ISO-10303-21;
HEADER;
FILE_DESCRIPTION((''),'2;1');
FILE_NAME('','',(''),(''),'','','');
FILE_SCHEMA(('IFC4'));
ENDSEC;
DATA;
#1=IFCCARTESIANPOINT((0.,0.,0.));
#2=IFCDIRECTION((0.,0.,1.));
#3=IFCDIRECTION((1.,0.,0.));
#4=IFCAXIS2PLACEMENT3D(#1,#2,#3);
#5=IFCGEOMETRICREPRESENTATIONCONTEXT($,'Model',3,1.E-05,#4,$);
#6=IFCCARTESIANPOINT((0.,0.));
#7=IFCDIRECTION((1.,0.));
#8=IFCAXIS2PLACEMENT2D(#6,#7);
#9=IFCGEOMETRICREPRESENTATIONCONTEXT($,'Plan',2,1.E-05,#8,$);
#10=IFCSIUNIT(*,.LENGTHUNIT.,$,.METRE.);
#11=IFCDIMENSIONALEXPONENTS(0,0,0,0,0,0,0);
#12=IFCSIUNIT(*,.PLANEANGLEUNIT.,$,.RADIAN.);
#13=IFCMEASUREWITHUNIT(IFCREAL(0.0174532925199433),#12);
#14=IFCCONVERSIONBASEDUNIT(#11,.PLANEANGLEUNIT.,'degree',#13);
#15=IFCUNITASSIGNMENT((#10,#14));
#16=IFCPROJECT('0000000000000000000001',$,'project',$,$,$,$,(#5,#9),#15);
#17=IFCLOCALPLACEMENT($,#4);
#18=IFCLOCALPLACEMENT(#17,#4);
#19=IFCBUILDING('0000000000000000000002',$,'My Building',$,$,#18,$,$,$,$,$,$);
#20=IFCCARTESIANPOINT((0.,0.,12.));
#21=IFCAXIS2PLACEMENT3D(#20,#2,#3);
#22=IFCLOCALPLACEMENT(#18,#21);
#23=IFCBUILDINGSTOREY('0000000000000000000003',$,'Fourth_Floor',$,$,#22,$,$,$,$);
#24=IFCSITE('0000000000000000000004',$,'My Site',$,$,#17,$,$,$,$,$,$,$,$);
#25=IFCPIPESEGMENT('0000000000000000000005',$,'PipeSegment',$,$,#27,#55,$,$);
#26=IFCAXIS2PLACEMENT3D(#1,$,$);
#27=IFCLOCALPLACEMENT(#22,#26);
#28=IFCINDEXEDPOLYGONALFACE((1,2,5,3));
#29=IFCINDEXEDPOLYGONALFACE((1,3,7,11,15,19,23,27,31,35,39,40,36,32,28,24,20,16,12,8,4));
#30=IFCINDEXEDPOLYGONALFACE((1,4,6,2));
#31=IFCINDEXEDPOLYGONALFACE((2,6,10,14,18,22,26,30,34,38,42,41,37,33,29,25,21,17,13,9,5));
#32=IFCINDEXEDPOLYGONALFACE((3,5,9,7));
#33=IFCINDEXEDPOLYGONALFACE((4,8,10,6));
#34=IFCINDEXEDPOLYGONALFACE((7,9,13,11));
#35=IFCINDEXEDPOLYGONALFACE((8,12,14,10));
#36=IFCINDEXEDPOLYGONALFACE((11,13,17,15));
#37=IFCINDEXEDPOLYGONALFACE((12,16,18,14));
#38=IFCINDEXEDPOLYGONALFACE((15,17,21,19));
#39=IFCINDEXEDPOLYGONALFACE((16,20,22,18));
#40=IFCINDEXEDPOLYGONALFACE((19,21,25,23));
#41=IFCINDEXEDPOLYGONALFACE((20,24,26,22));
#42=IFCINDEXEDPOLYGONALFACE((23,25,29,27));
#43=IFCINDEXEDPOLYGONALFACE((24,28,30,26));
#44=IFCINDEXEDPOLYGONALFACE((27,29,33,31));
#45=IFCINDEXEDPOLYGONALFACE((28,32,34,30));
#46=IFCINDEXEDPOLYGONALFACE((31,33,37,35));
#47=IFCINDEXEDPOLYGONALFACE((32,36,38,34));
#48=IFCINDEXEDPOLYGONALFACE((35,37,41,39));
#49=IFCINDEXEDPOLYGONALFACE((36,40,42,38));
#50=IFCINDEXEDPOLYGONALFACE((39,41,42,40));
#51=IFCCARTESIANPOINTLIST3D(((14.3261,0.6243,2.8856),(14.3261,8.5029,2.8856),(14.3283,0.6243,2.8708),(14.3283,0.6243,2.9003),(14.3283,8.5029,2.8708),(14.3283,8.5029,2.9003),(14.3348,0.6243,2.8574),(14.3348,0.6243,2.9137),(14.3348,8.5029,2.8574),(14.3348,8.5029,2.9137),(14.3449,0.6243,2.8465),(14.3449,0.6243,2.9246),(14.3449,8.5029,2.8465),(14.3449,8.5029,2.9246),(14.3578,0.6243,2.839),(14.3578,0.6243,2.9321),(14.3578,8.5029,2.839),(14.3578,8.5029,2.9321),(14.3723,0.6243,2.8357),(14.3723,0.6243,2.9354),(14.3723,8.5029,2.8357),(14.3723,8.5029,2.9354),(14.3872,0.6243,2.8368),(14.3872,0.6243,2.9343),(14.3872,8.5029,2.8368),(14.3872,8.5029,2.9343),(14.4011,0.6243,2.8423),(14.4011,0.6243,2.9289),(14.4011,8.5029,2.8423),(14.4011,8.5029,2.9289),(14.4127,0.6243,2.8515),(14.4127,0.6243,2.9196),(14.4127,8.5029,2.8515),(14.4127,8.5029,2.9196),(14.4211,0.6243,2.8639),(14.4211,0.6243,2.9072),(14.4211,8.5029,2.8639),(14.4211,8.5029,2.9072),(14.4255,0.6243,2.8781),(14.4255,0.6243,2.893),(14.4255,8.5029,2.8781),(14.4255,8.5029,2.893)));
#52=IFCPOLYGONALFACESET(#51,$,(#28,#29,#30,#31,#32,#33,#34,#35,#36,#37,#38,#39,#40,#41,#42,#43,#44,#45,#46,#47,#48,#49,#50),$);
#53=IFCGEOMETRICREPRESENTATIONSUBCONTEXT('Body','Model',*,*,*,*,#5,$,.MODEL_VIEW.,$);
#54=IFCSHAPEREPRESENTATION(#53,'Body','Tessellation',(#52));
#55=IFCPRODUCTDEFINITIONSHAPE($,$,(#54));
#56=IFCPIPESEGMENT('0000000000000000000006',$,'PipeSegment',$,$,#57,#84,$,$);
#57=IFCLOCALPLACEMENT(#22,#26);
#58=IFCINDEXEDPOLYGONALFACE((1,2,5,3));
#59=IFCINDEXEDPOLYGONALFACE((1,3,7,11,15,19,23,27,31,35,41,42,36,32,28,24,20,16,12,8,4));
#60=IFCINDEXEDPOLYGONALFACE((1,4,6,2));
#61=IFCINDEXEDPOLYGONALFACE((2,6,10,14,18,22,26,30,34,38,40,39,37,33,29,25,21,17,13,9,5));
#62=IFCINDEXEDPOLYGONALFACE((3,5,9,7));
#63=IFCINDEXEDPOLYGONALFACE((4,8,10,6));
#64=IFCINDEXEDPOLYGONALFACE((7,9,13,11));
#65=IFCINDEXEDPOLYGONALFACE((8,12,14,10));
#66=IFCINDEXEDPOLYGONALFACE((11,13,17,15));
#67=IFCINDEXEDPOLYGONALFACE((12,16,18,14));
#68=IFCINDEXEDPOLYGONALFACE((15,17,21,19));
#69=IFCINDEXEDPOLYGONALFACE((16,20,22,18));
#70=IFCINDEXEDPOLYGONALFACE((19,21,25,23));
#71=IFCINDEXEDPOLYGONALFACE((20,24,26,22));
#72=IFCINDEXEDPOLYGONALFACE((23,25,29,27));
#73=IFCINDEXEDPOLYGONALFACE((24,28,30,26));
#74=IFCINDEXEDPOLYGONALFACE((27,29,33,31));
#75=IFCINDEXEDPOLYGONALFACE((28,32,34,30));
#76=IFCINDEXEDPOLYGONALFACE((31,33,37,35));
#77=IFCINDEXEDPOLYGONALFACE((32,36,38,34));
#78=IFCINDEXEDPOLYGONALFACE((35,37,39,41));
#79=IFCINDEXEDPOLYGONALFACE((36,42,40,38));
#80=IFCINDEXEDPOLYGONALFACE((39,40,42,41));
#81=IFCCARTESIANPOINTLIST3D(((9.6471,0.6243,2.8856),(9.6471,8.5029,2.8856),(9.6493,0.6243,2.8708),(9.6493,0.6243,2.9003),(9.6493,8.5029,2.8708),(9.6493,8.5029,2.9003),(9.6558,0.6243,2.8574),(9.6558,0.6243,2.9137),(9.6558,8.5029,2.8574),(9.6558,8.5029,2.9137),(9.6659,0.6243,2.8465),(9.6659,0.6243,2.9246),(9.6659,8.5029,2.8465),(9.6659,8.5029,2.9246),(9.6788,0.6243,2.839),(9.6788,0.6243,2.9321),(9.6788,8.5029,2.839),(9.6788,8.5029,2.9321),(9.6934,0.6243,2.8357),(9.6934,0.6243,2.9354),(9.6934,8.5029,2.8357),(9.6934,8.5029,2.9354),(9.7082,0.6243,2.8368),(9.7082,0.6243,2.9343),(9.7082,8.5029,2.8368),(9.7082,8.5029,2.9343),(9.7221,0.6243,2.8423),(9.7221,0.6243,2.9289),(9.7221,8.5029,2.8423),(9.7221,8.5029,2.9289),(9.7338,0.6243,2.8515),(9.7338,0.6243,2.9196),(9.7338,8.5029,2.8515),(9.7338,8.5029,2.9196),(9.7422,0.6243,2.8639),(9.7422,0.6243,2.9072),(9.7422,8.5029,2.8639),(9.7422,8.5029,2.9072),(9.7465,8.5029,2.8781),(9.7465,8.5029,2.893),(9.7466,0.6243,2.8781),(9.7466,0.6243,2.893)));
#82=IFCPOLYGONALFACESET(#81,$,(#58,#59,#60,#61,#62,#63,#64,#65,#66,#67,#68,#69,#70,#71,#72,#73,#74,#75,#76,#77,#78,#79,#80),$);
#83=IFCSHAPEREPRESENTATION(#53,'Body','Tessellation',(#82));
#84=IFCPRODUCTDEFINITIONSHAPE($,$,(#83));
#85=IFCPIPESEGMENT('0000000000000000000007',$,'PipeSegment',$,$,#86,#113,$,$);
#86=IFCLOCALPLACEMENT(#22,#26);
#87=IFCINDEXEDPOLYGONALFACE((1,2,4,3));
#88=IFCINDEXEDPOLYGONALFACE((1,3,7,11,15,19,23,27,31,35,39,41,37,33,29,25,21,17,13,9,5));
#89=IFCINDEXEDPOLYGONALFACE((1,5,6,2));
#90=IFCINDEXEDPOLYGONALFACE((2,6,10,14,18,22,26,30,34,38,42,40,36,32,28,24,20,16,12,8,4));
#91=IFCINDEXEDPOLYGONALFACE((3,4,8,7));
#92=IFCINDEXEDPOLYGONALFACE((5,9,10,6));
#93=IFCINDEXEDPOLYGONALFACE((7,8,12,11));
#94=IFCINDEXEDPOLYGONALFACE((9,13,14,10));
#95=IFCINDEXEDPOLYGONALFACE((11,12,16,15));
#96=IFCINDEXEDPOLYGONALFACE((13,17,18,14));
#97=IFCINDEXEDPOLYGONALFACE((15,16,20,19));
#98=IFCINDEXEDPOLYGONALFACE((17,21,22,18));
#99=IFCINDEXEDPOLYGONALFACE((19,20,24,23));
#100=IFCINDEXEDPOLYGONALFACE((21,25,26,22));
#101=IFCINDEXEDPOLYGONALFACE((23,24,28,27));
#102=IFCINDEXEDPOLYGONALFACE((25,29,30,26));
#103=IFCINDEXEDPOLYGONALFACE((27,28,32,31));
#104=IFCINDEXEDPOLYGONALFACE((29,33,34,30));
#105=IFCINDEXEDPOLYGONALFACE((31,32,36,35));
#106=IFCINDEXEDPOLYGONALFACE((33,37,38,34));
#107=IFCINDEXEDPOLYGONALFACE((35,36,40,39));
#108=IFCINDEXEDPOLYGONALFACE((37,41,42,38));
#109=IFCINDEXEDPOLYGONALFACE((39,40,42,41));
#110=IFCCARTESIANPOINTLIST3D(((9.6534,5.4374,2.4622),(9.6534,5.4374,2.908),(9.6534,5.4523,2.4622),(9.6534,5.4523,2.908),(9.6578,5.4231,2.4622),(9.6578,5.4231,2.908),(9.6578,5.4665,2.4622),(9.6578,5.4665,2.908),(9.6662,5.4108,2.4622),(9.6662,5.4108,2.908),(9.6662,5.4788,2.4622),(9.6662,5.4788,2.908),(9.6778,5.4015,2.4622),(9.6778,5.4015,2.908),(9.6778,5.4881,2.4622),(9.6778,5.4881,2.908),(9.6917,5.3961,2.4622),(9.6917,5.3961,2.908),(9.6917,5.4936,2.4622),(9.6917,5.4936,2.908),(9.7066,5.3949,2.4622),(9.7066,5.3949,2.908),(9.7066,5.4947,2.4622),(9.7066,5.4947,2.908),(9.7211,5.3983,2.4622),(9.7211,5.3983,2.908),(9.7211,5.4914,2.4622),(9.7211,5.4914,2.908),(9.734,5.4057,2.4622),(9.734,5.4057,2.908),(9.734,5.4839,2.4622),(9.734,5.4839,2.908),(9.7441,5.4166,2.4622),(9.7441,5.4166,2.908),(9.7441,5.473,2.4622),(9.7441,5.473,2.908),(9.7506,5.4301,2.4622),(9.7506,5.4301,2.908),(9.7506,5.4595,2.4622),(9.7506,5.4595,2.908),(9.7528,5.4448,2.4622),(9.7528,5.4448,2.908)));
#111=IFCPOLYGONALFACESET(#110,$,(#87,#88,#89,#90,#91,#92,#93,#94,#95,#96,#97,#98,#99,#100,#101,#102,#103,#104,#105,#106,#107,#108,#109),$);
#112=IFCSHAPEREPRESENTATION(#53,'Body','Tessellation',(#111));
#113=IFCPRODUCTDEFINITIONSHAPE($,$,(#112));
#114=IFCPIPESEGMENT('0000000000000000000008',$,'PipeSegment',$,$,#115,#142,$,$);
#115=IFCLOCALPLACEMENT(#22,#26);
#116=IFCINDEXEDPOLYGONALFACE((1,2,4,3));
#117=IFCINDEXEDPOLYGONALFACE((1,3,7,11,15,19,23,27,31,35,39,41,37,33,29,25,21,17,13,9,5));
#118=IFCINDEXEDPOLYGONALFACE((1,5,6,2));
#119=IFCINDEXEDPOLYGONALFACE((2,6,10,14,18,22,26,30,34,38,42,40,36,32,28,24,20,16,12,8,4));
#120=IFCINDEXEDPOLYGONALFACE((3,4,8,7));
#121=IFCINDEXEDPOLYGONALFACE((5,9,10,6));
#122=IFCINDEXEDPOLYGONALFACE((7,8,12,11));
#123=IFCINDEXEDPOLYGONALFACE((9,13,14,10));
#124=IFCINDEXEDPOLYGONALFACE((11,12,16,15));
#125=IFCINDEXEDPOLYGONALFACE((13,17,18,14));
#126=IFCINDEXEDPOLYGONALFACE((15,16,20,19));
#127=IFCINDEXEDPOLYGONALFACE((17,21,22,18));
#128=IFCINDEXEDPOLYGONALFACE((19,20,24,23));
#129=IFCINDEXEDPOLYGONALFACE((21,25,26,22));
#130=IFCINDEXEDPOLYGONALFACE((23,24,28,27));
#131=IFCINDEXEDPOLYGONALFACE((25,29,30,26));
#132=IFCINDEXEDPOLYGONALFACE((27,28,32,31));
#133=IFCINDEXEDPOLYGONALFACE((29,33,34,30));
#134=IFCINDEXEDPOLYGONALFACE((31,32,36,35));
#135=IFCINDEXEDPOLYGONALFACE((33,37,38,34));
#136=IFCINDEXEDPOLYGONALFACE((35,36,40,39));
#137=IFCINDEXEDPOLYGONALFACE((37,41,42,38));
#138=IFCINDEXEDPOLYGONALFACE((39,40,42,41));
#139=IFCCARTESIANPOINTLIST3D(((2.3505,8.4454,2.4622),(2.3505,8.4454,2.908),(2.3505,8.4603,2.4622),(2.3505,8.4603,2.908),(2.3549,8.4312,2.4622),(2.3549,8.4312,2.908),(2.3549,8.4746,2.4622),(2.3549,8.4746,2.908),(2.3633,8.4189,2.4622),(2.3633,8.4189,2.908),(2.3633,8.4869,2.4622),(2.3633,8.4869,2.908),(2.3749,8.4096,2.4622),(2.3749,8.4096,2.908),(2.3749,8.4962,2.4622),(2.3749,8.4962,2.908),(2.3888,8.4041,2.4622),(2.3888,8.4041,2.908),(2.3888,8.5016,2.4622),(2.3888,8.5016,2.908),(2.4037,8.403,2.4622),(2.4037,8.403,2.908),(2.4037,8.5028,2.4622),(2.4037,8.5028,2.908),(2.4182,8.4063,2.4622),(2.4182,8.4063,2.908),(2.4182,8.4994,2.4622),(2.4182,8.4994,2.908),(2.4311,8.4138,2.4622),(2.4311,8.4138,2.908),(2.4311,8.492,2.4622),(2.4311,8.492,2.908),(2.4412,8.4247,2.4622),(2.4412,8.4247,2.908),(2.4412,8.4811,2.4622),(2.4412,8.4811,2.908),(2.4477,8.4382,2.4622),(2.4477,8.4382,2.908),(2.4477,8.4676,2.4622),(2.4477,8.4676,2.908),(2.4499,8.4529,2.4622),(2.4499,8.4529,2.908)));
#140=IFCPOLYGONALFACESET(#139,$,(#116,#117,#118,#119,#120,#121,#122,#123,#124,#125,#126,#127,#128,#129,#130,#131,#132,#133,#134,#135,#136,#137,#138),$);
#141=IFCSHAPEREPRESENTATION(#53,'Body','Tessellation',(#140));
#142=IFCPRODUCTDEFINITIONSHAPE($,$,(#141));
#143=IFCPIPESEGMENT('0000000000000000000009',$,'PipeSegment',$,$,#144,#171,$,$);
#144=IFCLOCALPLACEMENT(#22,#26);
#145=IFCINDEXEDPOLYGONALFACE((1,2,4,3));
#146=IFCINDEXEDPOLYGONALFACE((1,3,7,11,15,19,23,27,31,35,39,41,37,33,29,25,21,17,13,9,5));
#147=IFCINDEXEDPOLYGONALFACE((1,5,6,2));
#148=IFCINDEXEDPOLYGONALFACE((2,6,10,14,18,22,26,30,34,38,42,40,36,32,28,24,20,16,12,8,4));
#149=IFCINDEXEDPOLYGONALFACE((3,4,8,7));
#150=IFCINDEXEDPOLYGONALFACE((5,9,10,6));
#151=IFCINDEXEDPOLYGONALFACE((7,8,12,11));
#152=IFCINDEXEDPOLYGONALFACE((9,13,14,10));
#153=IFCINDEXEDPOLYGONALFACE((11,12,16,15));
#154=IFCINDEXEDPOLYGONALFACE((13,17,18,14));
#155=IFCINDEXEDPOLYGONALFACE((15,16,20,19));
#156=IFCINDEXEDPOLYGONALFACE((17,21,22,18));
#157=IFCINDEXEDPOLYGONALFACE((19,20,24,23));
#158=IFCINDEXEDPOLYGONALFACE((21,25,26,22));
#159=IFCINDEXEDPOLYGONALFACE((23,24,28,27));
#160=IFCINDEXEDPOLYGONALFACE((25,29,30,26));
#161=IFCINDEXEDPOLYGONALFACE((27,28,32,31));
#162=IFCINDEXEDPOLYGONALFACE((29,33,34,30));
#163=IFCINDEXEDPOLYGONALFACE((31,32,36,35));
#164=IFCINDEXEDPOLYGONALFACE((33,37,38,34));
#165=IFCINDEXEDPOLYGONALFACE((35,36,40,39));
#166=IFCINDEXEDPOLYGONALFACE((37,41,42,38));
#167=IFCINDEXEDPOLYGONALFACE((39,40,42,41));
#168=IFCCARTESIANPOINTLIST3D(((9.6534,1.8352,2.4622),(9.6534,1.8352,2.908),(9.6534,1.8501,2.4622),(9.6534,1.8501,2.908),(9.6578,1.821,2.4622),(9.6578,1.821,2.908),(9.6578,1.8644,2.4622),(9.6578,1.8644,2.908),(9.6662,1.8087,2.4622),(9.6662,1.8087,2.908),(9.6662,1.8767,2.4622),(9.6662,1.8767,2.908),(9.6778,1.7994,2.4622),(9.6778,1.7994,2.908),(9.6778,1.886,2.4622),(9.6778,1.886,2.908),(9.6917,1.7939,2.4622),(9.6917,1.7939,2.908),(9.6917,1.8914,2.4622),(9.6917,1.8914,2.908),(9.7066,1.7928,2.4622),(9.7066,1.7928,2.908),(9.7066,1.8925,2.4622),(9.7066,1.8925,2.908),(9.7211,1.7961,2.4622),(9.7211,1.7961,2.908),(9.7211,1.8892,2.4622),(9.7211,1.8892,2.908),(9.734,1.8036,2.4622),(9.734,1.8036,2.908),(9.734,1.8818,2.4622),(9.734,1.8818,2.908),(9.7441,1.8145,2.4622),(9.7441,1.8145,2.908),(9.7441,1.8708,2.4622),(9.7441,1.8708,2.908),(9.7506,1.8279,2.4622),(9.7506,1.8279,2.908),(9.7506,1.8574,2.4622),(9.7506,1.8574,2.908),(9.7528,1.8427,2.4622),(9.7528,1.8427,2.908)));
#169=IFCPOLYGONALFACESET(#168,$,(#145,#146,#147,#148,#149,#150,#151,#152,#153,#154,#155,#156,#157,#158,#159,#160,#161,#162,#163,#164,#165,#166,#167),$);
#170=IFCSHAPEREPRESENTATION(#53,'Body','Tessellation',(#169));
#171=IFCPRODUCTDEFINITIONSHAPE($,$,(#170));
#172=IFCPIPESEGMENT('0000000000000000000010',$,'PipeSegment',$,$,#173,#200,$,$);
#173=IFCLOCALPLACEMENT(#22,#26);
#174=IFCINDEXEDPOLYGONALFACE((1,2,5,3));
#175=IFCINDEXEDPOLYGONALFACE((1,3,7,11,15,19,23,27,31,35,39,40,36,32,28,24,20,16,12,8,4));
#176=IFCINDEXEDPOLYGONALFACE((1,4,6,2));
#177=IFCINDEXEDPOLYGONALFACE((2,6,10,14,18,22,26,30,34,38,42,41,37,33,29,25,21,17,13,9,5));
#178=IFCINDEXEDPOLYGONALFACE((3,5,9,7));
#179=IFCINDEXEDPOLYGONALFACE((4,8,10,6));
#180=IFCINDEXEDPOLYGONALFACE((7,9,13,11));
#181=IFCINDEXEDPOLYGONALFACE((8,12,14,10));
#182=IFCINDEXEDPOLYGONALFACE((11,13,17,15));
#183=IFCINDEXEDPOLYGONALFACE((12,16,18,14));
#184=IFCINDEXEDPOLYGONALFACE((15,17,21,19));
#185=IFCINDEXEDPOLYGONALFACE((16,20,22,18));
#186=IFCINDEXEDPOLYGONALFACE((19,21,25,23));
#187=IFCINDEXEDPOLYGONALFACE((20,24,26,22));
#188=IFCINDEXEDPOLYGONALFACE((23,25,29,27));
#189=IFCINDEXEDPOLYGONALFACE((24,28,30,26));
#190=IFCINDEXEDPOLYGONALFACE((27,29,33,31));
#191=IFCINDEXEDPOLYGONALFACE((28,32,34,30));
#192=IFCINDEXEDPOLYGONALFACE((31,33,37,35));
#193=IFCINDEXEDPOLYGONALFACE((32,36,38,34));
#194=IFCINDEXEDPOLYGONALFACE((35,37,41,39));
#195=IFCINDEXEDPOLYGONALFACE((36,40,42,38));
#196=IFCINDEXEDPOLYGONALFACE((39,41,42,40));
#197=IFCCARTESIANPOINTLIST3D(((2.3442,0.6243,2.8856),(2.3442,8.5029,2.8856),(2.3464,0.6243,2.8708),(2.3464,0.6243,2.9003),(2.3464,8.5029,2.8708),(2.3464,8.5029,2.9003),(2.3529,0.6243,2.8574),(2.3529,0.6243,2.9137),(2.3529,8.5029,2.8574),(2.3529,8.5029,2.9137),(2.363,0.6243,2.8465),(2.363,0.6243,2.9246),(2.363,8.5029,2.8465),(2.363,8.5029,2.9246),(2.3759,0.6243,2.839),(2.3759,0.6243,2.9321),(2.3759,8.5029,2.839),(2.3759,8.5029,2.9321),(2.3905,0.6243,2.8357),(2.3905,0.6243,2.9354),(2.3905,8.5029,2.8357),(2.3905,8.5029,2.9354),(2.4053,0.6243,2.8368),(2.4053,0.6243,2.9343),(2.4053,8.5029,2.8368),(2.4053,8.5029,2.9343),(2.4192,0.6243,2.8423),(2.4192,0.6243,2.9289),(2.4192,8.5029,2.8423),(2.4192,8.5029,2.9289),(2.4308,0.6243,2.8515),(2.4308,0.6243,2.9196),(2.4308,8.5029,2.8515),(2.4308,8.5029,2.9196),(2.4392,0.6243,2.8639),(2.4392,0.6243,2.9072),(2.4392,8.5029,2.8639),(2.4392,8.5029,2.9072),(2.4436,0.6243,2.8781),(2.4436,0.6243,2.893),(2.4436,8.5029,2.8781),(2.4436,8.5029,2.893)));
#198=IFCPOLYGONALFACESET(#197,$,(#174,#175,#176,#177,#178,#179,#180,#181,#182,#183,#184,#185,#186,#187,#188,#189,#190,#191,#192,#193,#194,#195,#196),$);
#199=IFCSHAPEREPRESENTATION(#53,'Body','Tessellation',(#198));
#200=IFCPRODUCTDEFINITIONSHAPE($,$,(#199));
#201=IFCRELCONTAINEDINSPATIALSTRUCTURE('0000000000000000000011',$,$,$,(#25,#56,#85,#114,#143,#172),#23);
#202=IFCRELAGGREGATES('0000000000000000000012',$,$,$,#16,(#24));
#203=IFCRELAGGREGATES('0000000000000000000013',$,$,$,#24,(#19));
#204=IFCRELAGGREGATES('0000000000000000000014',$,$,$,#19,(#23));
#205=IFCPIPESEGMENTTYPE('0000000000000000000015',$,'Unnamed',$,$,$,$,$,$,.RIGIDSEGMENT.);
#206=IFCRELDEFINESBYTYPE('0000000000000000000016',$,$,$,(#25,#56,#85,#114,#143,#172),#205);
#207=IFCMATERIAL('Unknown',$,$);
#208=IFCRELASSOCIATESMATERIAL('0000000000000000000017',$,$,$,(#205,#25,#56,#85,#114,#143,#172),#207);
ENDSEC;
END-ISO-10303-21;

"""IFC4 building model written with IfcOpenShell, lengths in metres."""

from ifc_helpers import new_model, entity, si_unit, converted_unit, frame, origin_with_axes, origin_2d_with_axis, place, context, subcontext, project, spatial, circle, extrude, material, material_profile, profile_set, profile_usage, type_object, element, save


model = new_model("IFC4")

# Units and contexts
model_context = context("Model", 3, precision=1e-05, world=origin_with_axes())
plan_context = context("Plan", 2, precision=1e-05, world=origin_2d_with_axis())
body_context_1 = subcontext(model_context, "Body", "Model", "MODEL_VIEW")
ifc_project = project(units=[si_unit("LENGTHUNIT", "METRE"), converted_unit("PLANEANGLEUNIT", "degree", entity("IfcReal", 0.0174532925199433), si_unit("PLANEANGLEUNIT", "RADIAN"), dimensions=[0, 0, 0, 0, 0, 0, 0])], contexts=[model_context, plan_context])

# Site, building, storey
site_placement = place(None, origin_with_axes())
site = spatial("IfcSite", under=ifc_project, at=site_placement, Name="My Site")
building_placement = place(site_placement, origin_with_axes())
building = spatial("IfcBuilding", under=site, at=building_placement, Name="My Building")
storey_placement = place(building_placement, frame((0.0, 0.0, 12.0), z_axis=(0.0, 0.0, 1.0), x_axis=(1.0, 0.0, 0.0)))
storey = spatial("IfcBuildingStorey", under=building, at=storey_placement, Name="Fourth_Floor")

# Shared definitions
ifc_material = material(Name="Unknown")

# Pipe segments
ifc_material_profile_1 = material_profile(ifc_material, circle(Radius=0.05))
ifc_profile_set_1 = profile_set([ifc_material_profile_1])
pipe_segment_type = type_object("IfcPipeSegmentType", Name="Unnamed", PredefinedType="RIGIDSEGMENT", material=ifc_profile_set_1)
ifc_profile_usage_1 = profile_usage(ifc_profile_set_1, cardinal=5)
pipe_segment_1_placement = place(storey_placement, frame((14.3761, 0.6243, 2.8856), z_axis=(0.0, 1.0, 0.0), x_axis=(-1.0, 0.0, 0.0)))
element("IfcPipeSegment", 1, at=pipe_segment_1_placement, inside=storey, type_object=pipe_segment_type, material=ifc_profile_usage_1, Name="PipeSegment", context=body_context_1, shape_type="SweptSolid", body=[
    extrude(circle(Radius=0.05), origin_with_axes(), (0.0, 0.0, 1.0), 7.8786),
])
ifc_profile_usage_2 = profile_usage(ifc_profile_set_1, cardinal=5)
pipe_segment_2_placement = place(storey_placement, frame((9.6971, 0.6243, 2.8856), z_axis=(0.0, 1.0, 0.0), x_axis=(-1.0, 0.0, 0.0)))
element("IfcPipeSegment", 2, at=pipe_segment_2_placement, inside=storey, type_object=pipe_segment_type, material=ifc_profile_usage_2, Name="PipeSegment", context=body_context_1, shape_type="SweptSolid", body=[
    extrude(circle(Radius=0.05), origin_with_axes(), (0.0, 0.0, 1.0), 7.8786),
])
ifc_profile_usage_3 = profile_usage(ifc_profile_set_1, cardinal=5)
pipe_segment_3_placement = place(storey_placement, frame((9.7028, 5.4448, 2.908), z_axis=(0.0, 0.0, -1.0), x_axis=(1.0, 0.0, 0.0)))
element("IfcPipeSegment", 3, at=pipe_segment_3_placement, inside=storey, type_object=pipe_segment_type, material=ifc_profile_usage_3, Name="PipeSegment", context=body_context_1, shape_type="SweptSolid", body=[
    extrude(circle(Radius=0.05), origin_with_axes(), (0.0, 0.0, 1.0), 0.4458),
])
ifc_profile_usage_4 = profile_usage(ifc_profile_set_1, cardinal=5)
pipe_segment_4_placement = place(storey_placement, frame((2.3999, 8.4529, 2.908), z_axis=(0.0, 0.0, -1.0), x_axis=(1.0, 0.0, 0.0)))
element("IfcPipeSegment", 4, at=pipe_segment_4_placement, inside=storey, type_object=pipe_segment_type, material=ifc_profile_usage_4, Name="PipeSegment", context=body_context_1, shape_type="SweptSolid", body=[
    extrude(circle(Radius=0.05), origin_with_axes(), (0.0, 0.0, 1.0), 0.4458),
])
ifc_profile_usage_5 = profile_usage(ifc_profile_set_1, cardinal=5)
pipe_segment_5_placement = place(storey_placement, frame((9.7028, 1.8427, 2.908), z_axis=(0.0, 0.0, -1.0), x_axis=(1.0, 0.0, 0.0)))
element("IfcPipeSegment", 5, at=pipe_segment_5_placement, inside=storey, type_object=pipe_segment_type, material=ifc_profile_usage_5, Name="PipeSegment", context=body_context_1, shape_type="SweptSolid", body=[
    extrude(circle(Radius=0.05), origin_with_axes(), (0.0, 0.0, 1.0), 0.4458),
])
ifc_profile_usage_6 = profile_usage(ifc_profile_set_1, cardinal=5)
pipe_segment_6_placement = place(storey_placement, frame((2.3942, 0.6243, 2.8856), z_axis=(0.0, 1.0, 0.0), x_axis=(-1.0, 0.0, 0.0)))
element("IfcPipeSegment", 6, at=pipe_segment_6_placement, inside=storey, type_object=pipe_segment_type, material=ifc_profile_usage_6, Name="PipeSegment", context=body_context_1, shape_type="SweptSolid", body=[
    extrude(circle(Radius=0.05), origin_with_axes(), (0.0, 0.0, 1.0), 7.8786),
])

save(model, "model.ifc")
